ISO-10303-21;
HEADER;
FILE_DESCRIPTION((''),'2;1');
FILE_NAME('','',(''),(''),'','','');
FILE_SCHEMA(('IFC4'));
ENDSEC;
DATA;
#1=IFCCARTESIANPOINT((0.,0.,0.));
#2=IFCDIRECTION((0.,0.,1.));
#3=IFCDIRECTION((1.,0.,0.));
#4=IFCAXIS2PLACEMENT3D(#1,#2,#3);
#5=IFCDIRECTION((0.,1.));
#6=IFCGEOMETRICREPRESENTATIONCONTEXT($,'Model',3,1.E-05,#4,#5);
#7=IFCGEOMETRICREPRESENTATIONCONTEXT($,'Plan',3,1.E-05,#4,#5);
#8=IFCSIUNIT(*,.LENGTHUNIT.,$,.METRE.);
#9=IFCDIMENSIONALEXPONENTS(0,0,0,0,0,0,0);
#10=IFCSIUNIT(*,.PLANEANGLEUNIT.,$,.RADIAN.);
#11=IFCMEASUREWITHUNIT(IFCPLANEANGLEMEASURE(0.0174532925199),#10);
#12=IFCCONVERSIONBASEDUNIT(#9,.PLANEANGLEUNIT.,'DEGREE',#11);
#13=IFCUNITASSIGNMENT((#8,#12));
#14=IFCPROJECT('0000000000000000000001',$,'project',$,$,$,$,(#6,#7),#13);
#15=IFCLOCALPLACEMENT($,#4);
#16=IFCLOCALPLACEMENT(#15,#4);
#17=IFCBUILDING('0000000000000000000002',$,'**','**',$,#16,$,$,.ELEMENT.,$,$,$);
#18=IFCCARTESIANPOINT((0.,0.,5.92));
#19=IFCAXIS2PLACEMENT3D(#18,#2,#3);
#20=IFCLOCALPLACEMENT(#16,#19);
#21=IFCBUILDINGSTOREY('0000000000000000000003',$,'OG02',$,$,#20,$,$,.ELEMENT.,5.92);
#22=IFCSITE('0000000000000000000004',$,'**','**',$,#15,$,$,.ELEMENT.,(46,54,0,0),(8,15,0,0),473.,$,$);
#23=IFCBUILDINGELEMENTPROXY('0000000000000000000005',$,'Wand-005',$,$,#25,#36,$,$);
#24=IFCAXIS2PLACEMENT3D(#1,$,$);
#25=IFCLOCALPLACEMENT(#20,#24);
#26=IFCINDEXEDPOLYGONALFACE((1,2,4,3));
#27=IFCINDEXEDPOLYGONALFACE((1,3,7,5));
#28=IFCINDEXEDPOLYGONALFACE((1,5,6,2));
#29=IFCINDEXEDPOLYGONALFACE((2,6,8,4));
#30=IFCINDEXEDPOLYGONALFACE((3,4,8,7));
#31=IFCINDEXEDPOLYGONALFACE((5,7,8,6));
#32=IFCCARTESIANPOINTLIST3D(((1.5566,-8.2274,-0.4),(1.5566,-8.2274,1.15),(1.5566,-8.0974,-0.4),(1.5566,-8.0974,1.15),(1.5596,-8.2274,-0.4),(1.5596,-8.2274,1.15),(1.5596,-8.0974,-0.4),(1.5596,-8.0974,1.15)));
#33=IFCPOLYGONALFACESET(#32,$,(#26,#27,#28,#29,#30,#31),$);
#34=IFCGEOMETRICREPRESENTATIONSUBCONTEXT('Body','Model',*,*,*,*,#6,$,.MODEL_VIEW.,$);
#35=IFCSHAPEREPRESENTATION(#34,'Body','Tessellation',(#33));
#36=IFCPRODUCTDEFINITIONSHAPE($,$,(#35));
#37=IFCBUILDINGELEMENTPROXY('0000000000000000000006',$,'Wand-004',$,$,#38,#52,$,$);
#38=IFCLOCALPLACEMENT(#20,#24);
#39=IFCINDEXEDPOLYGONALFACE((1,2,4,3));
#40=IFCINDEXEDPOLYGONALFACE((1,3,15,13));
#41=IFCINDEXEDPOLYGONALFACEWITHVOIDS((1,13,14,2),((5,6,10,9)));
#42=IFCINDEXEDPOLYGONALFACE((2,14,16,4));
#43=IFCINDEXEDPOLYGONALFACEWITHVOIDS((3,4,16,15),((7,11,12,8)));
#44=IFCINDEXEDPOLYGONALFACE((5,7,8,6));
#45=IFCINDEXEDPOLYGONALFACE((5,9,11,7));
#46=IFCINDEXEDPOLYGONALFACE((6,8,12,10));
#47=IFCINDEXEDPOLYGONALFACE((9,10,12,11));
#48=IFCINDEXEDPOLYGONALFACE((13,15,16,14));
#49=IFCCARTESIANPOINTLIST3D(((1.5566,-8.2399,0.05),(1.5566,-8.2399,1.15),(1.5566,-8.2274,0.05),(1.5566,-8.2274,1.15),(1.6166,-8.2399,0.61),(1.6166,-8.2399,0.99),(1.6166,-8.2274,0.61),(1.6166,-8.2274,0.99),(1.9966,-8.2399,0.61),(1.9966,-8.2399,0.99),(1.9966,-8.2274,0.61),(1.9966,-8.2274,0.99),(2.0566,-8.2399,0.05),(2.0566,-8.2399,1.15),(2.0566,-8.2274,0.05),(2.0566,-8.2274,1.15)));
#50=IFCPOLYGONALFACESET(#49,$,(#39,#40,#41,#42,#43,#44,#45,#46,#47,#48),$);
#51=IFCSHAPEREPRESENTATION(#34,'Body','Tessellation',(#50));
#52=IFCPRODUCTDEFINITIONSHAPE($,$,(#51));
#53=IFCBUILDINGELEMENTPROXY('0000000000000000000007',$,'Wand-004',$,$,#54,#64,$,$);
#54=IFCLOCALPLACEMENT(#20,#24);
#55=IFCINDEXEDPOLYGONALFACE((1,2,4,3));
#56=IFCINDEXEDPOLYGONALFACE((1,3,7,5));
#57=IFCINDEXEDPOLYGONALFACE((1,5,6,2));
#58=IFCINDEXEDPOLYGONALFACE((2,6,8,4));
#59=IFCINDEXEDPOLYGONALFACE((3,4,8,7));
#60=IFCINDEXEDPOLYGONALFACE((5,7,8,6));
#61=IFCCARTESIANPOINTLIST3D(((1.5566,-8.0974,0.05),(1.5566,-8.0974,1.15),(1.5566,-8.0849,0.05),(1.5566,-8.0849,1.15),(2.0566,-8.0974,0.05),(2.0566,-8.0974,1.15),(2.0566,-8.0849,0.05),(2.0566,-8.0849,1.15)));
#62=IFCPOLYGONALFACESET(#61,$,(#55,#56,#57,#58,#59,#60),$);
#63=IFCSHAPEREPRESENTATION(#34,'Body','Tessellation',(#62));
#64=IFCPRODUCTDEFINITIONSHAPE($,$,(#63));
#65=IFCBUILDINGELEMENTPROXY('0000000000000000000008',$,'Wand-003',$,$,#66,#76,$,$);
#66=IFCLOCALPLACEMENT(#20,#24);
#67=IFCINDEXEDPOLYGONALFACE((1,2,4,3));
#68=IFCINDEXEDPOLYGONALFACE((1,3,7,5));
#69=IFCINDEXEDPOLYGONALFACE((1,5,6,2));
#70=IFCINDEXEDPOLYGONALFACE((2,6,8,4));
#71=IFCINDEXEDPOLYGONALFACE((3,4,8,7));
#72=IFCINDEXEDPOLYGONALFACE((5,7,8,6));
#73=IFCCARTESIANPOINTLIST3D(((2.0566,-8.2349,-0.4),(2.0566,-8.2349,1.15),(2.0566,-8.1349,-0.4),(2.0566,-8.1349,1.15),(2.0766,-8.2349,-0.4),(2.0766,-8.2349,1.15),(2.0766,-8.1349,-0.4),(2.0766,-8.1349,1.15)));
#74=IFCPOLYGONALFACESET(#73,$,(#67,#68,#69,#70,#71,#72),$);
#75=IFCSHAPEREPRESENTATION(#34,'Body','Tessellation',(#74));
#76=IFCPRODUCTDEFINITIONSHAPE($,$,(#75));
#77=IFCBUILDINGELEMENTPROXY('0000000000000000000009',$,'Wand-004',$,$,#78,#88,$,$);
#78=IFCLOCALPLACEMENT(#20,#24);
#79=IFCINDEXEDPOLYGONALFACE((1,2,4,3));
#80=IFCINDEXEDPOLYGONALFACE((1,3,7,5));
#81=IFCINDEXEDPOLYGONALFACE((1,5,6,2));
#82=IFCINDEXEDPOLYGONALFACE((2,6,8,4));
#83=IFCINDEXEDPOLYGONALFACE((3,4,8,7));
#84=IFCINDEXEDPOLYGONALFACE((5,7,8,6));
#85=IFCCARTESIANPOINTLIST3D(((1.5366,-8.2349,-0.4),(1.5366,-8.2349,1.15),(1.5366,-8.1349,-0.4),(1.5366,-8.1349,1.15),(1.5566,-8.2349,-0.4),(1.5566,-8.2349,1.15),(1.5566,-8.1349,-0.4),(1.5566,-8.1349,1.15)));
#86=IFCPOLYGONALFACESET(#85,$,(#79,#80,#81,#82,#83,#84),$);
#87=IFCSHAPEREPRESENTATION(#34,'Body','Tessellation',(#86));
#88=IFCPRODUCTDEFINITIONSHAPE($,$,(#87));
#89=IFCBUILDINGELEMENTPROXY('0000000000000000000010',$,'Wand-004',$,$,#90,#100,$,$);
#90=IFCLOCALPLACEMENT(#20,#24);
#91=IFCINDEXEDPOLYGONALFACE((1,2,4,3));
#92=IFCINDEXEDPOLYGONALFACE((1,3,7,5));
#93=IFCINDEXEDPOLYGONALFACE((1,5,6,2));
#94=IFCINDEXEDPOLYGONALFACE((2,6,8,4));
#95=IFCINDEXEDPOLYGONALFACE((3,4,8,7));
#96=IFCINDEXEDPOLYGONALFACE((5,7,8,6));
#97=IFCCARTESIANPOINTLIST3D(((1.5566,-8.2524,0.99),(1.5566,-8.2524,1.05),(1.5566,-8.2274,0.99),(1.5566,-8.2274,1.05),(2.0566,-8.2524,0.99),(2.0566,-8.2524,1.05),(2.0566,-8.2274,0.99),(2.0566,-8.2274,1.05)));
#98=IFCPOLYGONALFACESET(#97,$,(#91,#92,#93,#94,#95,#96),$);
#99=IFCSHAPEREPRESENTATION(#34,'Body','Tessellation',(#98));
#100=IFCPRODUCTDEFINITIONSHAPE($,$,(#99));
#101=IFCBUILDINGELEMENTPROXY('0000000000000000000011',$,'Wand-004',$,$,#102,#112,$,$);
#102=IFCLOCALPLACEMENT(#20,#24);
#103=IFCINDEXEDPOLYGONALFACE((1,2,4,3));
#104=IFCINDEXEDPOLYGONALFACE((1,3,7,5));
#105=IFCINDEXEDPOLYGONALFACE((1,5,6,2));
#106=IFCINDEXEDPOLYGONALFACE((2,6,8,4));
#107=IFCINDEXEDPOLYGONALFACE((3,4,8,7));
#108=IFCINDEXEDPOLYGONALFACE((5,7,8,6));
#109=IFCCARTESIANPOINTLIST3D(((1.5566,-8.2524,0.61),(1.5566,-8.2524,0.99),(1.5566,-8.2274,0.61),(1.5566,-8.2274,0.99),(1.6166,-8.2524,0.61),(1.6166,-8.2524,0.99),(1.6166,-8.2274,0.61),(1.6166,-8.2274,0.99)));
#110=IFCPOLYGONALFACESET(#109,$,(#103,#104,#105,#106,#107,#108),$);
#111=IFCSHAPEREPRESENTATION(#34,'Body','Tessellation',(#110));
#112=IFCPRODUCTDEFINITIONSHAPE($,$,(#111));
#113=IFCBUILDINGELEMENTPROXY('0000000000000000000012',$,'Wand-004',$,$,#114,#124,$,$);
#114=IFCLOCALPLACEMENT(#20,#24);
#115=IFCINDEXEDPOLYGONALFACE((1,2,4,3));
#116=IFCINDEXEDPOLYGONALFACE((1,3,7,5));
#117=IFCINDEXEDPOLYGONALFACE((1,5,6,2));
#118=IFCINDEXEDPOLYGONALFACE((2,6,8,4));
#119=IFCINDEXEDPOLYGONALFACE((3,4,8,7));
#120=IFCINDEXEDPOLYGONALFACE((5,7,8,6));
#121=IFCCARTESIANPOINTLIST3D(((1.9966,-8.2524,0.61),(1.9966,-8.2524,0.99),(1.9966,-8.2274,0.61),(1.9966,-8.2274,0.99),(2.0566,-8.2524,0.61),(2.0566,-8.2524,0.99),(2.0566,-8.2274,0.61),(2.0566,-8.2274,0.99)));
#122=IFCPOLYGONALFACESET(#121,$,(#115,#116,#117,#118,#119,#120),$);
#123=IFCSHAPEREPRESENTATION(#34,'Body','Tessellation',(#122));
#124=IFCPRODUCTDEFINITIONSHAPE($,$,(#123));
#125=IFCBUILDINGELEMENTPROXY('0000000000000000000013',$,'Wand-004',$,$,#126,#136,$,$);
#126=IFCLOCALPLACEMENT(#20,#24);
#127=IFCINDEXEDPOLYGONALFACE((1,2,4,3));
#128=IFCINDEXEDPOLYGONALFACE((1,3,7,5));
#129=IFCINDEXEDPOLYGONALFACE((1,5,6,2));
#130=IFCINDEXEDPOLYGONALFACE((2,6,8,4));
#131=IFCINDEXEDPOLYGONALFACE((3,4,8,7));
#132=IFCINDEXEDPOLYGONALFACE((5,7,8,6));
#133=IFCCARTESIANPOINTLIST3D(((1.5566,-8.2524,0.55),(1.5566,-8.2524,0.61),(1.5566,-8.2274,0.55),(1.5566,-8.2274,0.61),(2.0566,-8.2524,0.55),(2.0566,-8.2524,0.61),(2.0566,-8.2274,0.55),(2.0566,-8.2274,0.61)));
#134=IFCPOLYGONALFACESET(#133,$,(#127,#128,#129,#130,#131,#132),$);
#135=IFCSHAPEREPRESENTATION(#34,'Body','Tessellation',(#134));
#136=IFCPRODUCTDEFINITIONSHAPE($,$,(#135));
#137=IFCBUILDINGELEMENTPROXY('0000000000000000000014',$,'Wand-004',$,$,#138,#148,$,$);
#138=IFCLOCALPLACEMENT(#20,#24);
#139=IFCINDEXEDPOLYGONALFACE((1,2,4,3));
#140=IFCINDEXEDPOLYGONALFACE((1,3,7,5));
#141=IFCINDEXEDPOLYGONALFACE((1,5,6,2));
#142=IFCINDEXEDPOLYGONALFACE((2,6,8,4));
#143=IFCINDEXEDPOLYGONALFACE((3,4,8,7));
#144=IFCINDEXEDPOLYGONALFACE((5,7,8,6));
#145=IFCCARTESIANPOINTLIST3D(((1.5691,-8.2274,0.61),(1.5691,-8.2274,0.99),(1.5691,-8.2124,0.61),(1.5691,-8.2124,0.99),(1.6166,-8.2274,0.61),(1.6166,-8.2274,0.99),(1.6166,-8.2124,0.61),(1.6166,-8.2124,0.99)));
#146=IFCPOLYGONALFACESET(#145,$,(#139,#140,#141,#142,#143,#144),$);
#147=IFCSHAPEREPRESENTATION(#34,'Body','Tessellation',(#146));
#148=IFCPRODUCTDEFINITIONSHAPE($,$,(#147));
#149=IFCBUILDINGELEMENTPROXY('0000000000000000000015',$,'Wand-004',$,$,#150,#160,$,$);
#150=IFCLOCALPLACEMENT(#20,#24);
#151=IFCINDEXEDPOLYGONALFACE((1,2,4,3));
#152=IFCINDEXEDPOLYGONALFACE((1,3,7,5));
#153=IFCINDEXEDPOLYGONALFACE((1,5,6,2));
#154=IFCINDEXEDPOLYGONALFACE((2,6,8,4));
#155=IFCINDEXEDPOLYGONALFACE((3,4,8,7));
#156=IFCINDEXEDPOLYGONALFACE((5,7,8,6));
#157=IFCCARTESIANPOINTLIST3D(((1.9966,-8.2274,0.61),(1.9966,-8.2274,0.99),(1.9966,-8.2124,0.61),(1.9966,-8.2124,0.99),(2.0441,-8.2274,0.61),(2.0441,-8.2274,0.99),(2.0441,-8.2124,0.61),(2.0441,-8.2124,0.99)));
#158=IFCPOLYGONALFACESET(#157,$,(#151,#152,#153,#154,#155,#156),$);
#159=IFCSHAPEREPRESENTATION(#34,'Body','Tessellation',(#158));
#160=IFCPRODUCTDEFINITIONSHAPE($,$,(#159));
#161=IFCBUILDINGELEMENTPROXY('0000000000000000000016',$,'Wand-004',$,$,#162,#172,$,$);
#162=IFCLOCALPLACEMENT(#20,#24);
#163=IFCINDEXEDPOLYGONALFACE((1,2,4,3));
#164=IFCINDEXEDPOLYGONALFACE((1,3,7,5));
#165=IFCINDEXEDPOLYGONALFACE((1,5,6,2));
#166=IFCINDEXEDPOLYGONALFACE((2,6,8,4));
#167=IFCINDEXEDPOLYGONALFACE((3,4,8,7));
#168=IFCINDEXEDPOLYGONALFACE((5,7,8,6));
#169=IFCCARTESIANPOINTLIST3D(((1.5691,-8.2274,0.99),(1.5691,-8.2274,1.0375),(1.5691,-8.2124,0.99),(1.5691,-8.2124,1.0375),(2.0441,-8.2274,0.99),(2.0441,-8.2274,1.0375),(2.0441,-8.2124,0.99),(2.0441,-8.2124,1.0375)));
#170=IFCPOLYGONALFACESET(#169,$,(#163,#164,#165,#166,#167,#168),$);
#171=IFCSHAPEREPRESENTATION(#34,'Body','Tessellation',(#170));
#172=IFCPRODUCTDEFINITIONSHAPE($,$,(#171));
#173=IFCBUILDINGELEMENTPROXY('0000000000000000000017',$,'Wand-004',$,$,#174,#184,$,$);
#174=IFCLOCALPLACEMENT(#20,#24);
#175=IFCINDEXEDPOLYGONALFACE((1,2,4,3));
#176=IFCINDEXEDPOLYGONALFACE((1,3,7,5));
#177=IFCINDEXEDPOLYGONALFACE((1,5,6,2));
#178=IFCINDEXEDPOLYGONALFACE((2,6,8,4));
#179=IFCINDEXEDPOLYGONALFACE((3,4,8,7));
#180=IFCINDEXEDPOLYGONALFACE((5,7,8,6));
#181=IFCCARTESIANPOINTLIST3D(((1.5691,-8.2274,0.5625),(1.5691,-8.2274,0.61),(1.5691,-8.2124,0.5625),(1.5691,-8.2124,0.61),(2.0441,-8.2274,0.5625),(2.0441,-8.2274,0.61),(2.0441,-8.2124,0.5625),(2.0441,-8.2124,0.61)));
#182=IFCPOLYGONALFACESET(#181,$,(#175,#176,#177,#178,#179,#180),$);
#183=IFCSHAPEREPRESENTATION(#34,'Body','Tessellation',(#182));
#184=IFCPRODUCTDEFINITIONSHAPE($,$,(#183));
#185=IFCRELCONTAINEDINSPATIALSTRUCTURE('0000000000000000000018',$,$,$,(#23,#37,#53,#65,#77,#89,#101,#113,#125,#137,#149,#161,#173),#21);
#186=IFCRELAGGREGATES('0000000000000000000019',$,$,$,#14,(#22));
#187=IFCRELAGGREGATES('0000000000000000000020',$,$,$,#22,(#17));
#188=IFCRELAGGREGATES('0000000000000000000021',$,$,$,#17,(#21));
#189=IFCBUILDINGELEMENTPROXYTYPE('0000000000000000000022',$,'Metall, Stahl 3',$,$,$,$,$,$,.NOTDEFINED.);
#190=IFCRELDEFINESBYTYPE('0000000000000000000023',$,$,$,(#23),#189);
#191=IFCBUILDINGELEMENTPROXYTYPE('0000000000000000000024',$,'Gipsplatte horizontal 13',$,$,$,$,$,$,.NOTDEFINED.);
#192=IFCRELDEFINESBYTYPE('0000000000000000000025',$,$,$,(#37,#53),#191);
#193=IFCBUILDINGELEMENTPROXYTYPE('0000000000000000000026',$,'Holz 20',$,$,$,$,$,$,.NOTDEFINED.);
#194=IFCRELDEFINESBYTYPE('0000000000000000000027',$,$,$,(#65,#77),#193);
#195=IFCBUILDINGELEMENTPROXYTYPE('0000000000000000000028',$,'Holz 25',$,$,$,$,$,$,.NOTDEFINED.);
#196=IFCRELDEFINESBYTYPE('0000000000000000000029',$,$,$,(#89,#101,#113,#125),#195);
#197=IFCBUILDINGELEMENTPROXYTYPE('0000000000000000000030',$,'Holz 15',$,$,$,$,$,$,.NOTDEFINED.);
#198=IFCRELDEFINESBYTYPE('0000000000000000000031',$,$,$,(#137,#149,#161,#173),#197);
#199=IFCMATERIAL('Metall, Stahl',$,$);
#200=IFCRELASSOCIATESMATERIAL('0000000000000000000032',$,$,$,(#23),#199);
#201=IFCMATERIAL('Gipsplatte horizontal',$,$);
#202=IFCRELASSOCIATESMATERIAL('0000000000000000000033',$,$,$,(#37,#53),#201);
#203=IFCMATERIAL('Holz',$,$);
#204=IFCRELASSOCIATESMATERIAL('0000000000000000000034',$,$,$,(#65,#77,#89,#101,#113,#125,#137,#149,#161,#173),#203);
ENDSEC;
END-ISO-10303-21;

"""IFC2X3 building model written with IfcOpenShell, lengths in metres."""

from ifc_helpers import new_model, entity, si_unit, converted_unit, direction, frame, origin_with_axes, origin_2d_with_axis, place, context, subcontext, project, spatial, polyline, rectangle, outline, extrude, material, type_object, element, save


model = new_model("IFC2X3")

# Units and contexts
model_context = context("Model", 3, precision=1e-05, world=origin_with_axes(), true_north=direction((0.0, 1.0)))
plan_context = context("Plan", 3, precision=1e-05, world=origin_with_axes(), true_north=direction((0.0, 1.0)))
body_context = subcontext(model_context, "Body", "Model", "MODEL_VIEW")
ifc_project = project(units=[si_unit("LENGTHUNIT", "METRE"), converted_unit("PLANEANGLEUNIT", "DEGREE", entity("IfcPlaneAngleMeasure", 0.0174532925199), si_unit("PLANEANGLEUNIT", "RADIAN"), dimensions=[0, 0, 0, 0, 0, 0, 0])], contexts=[model_context, plan_context])

# Site, building, storey
site_placement = place(None, origin_with_axes())
site = spatial("IfcSite", under=ifc_project, at=site_placement, Name="**", Description="**", CompositionType="ELEMENT", RefLatitude=(46, 54, 0, 0), RefLongitude=(8, 15, 0, 0), RefElevation=473.0)
building_placement = place(site_placement, origin_with_axes())
building = spatial("IfcBuilding", under=site, at=building_placement, Name="**", Description="**", CompositionType="ELEMENT")
storey_placement = place(building_placement, frame((0.0, 0.0, 5.92), z_axis=(0.0, 0.0, 1.0), x_axis=(1.0, 0.0, 0.0)))
storey = spatial("IfcBuildingStorey", under=building, at=storey_placement, Name="OG02", CompositionType="ELEMENT", Elevation=5.92)

# Building element proxy
ifc_material_1 = material(Name="Metall, Stahl")
building_element_proxy_type_1 = type_object("IfcBuildingElementProxyType", Name="Metall, Stahl 3", PredefinedType="NOTDEFINED")
proxy_1_placement = place(storey_placement, frame((1.5566, -8.0974, -0.4), z_axis=(0.0, 0.0, 1.0), x_axis=(0.0, -1.0, 0.0)))
element("IfcBuildingElementProxy", 1, at=proxy_1_placement, inside=storey, type_object=building_element_proxy_type_1, material=ifc_material_1, Name="Wand-005", context=body_context, shape_type="SweptSolid", body=[
    extrude(outline(polyline([(0.0, 0.0), (0.13, 0.0), (0.13, 0.003), (0.0, 0.003), (0.0, 0.0)])), origin_with_axes(), (0.0, 0.0, 1.0), 1.55),
])

# Building element proxy, opening
ifc_material_2 = material(Name="Gipsplatte horizontal")
building_element_proxy_type_2 = type_object("IfcBuildingElementProxyType", Name="Gipsplatte horizontal 13", PredefinedType="NOTDEFINED")
proxy_2_placement = place(storey_placement, frame((1.5566, -8.2399, 0.05), z_axis=(0.0, 0.0, 1.0), x_axis=(1.0, 0.0, 0.0)))
proxy_2 = element("IfcBuildingElementProxy", 2, at=proxy_2_placement, inside=storey, type_object=building_element_proxy_type_2, material=ifc_material_2, Name="Wand-004", context=body_context, shape_type="SweptSolid", body=[
    extrude(outline(polyline([(0.0, 0.0), (0.5, 0.0), (0.5, 0.0125), (0.0, 0.0125), (0.0, 0.0)])), origin_with_axes(), (0.0, 0.0, 1.0), 1.1),
])
opening_placement = place(proxy_2_placement, frame((-1.5566, 8.2399, -5.97), z_axis=(0.0, 0.0, 1.0), x_axis=(1.0, 0.0, 0.0)))
element("IfcOpeningElement", 3, at=opening_placement, cuts=proxy_2, context=body_context, shape_type="SweptSolid", body=[
    extrude(rectangle(XDim=0.38, YDim=0.38, at=origin_2d_with_axis()), frame((1.8066, -8.2524, 6.72), z_axis=(0.0, -1.0, 0.0), x_axis=(1.0, 0.0, 0.0)), (0.0, 0.0, -1.0), 0.0375),
])

# Building element proxies
proxy_3_placement = place(storey_placement, frame((1.5566, -8.0849, 0.05), z_axis=(0.0, 0.0, 1.0), x_axis=(1.0, 0.0, 0.0)))
element("IfcBuildingElementProxy", 4, at=proxy_3_placement, inside=storey, type_object=building_element_proxy_type_2, material=ifc_material_2, Name="Wand-004", context=body_context, shape_type="SweptSolid", body=[
    extrude(outline(polyline([(0.0, -0.0125), (0.5, -0.0125), (0.5, 0.0), (0.0, 0.0), (0.0, -0.0125)])), origin_with_axes(), (0.0, 0.0, 1.0), 1.1),
])
ifc_material_3 = material(Name="Holz")
building_element_proxy_type_3 = type_object("IfcBuildingElementProxyType", Name="Holz 20", PredefinedType="NOTDEFINED")
proxy_4_placement = place(storey_placement, frame((2.0766, -8.1349, -0.4), z_axis=(0.0, 0.0, 1.0), x_axis=(0.0, -1.0, 0.0)))
element("IfcBuildingElementProxy", 5, at=proxy_4_placement, inside=storey, type_object=building_element_proxy_type_3, material=ifc_material_3, Name="Wand-003", context=body_context, shape_type="SweptSolid", body=[
    extrude(outline(polyline([(0.0, -0.02), (0.1, -0.02), (0.1, 0.0), (0.0, 0.0), (0.0, -0.02)])), origin_with_axes(), (0.0, 0.0, 1.0), 1.55),
])
proxy_5_placement = place(storey_placement, frame((1.5366, -8.1349, -0.4), z_axis=(0.0, 0.0, 1.0), x_axis=(0.0, -1.0, 0.0)))
element("IfcBuildingElementProxy", 6, at=proxy_5_placement, inside=storey, type_object=building_element_proxy_type_3, material=ifc_material_3, Name="Wand-004", context=body_context, shape_type="SweptSolid", body=[
    extrude(outline(polyline([(0.0, 0.0), (0.1, 0.0), (0.1, 0.02), (0.0, 0.02), (0.0, 0.0)])), origin_with_axes(), (0.0, 0.0, 1.0), 1.55),
])
building_element_proxy_type_4 = type_object("IfcBuildingElementProxyType", Name="Holz 25", PredefinedType="NOTDEFINED")
proxy_6_placement = place(storey_placement, frame((2.0566, -8.2274, 0.99), z_axis=(0.0, 0.0, 1.0), x_axis=(-1.0, 0.0, 0.0)))
element("IfcBuildingElementProxy", 7, at=proxy_6_placement, inside=storey, type_object=building_element_proxy_type_4, material=ifc_material_3, Name="Wand-004", context=body_context, shape_type="SweptSolid", body=[
    extrude(outline(polyline([(0.0, 0.0), (0.5, 0.0), (0.5, 0.025), (0.0, 0.025), (0.0, 0.0)])), origin_with_axes(), (0.0, 0.0, 1.0), 0.06),
])
for number, where, z_axis, x_axis, name in (
    (8, (1.5566, -8.2524, 0.61), (0.0, 0.0, 1.0), (1.0, 0.0, 0.0), "Wand-004"),
    (9, (1.9966, -8.2524, 0.61), (0.0, 0.0, 1.0), (1.0, 0.0, 0.0), "Wand-004"),
):
    element("IfcBuildingElementProxy", number, at=place(storey_placement, frame(where, z_axis=z_axis, x_axis=x_axis)), inside=storey, type_object=building_element_proxy_type_4, material=ifc_material_3, Name=name, context=body_context, shape_type="SweptSolid", body=[
        extrude(outline(polyline([(0.0, 0.0), (0.06, 0.0), (0.06, 0.025), (0.0, 0.025), (0.0, 0.0)])), origin_with_axes(), (0.0, 0.0, 1.0), 0.38),
    ])
proxy_7_placement = place(storey_placement, frame((2.0566, -8.2274, 0.55), z_axis=(0.0, 0.0, 1.0), x_axis=(-1.0, 0.0, 0.0)))
element("IfcBuildingElementProxy", 10, at=proxy_7_placement, inside=storey, type_object=building_element_proxy_type_4, material=ifc_material_3, Name="Wand-004", context=body_context, shape_type="SweptSolid", body=[
    extrude(outline(polyline([(0.0, 0.0), (0.5, 0.0), (0.5, 0.025), (0.0, 0.025), (0.0, 0.0)])), origin_with_axes(), (0.0, 0.0, 1.0), 0.06),
])
building_element_proxy_type_5 = type_object("IfcBuildingElementProxyType", Name="Holz 15", PredefinedType="NOTDEFINED")
for number, where, z_axis, x_axis, name in (
    (11, (1.5691, -8.2274, 0.61), (0.0, 0.0, 1.0), (1.0, 0.0, 0.0), "Wand-004"),
    (12, (1.9966, -8.2274, 0.61), (0.0, 0.0, 1.0), (1.0, 0.0, 0.0), "Wand-004"),
):
    element("IfcBuildingElementProxy", number, at=place(storey_placement, frame(where, z_axis=z_axis, x_axis=x_axis)), inside=storey, type_object=building_element_proxy_type_5, material=ifc_material_3, Name=name, context=body_context, shape_type="SweptSolid", body=[
        extrude(outline(polyline([(0.0, 0.0), (0.0475, 0.0), (0.0475, 0.015), (0.0, 0.015), (0.0, 0.0)])), origin_with_axes(), (0.0, 0.0, 1.0), 0.38),
    ])
for number, where, z_axis, x_axis, name in (
    (13, (2.0441, -8.2124, 0.99), (0.0, 0.0, 1.0), (-1.0, 0.0, 0.0), "Wand-004"),
    (14, (2.0441, -8.2124, 0.5625), (0.0, 0.0, 1.0), (-1.0, 0.0, 0.0), "Wand-004"),
):
    element("IfcBuildingElementProxy", number, at=place(storey_placement, frame(where, z_axis=z_axis, x_axis=x_axis)), inside=storey, type_object=building_element_proxy_type_5, material=ifc_material_3, Name=name, context=body_context, shape_type="SweptSolid", body=[
        extrude(outline(polyline([(0.0, 0.0), (0.475, 0.0), (0.475, 0.015), (0.0, 0.015), (0.0, 0.0)])), origin_with_axes(), (0.0, 0.0, 1.0), 0.0475),
    ])

save(model, "model.ifc")
